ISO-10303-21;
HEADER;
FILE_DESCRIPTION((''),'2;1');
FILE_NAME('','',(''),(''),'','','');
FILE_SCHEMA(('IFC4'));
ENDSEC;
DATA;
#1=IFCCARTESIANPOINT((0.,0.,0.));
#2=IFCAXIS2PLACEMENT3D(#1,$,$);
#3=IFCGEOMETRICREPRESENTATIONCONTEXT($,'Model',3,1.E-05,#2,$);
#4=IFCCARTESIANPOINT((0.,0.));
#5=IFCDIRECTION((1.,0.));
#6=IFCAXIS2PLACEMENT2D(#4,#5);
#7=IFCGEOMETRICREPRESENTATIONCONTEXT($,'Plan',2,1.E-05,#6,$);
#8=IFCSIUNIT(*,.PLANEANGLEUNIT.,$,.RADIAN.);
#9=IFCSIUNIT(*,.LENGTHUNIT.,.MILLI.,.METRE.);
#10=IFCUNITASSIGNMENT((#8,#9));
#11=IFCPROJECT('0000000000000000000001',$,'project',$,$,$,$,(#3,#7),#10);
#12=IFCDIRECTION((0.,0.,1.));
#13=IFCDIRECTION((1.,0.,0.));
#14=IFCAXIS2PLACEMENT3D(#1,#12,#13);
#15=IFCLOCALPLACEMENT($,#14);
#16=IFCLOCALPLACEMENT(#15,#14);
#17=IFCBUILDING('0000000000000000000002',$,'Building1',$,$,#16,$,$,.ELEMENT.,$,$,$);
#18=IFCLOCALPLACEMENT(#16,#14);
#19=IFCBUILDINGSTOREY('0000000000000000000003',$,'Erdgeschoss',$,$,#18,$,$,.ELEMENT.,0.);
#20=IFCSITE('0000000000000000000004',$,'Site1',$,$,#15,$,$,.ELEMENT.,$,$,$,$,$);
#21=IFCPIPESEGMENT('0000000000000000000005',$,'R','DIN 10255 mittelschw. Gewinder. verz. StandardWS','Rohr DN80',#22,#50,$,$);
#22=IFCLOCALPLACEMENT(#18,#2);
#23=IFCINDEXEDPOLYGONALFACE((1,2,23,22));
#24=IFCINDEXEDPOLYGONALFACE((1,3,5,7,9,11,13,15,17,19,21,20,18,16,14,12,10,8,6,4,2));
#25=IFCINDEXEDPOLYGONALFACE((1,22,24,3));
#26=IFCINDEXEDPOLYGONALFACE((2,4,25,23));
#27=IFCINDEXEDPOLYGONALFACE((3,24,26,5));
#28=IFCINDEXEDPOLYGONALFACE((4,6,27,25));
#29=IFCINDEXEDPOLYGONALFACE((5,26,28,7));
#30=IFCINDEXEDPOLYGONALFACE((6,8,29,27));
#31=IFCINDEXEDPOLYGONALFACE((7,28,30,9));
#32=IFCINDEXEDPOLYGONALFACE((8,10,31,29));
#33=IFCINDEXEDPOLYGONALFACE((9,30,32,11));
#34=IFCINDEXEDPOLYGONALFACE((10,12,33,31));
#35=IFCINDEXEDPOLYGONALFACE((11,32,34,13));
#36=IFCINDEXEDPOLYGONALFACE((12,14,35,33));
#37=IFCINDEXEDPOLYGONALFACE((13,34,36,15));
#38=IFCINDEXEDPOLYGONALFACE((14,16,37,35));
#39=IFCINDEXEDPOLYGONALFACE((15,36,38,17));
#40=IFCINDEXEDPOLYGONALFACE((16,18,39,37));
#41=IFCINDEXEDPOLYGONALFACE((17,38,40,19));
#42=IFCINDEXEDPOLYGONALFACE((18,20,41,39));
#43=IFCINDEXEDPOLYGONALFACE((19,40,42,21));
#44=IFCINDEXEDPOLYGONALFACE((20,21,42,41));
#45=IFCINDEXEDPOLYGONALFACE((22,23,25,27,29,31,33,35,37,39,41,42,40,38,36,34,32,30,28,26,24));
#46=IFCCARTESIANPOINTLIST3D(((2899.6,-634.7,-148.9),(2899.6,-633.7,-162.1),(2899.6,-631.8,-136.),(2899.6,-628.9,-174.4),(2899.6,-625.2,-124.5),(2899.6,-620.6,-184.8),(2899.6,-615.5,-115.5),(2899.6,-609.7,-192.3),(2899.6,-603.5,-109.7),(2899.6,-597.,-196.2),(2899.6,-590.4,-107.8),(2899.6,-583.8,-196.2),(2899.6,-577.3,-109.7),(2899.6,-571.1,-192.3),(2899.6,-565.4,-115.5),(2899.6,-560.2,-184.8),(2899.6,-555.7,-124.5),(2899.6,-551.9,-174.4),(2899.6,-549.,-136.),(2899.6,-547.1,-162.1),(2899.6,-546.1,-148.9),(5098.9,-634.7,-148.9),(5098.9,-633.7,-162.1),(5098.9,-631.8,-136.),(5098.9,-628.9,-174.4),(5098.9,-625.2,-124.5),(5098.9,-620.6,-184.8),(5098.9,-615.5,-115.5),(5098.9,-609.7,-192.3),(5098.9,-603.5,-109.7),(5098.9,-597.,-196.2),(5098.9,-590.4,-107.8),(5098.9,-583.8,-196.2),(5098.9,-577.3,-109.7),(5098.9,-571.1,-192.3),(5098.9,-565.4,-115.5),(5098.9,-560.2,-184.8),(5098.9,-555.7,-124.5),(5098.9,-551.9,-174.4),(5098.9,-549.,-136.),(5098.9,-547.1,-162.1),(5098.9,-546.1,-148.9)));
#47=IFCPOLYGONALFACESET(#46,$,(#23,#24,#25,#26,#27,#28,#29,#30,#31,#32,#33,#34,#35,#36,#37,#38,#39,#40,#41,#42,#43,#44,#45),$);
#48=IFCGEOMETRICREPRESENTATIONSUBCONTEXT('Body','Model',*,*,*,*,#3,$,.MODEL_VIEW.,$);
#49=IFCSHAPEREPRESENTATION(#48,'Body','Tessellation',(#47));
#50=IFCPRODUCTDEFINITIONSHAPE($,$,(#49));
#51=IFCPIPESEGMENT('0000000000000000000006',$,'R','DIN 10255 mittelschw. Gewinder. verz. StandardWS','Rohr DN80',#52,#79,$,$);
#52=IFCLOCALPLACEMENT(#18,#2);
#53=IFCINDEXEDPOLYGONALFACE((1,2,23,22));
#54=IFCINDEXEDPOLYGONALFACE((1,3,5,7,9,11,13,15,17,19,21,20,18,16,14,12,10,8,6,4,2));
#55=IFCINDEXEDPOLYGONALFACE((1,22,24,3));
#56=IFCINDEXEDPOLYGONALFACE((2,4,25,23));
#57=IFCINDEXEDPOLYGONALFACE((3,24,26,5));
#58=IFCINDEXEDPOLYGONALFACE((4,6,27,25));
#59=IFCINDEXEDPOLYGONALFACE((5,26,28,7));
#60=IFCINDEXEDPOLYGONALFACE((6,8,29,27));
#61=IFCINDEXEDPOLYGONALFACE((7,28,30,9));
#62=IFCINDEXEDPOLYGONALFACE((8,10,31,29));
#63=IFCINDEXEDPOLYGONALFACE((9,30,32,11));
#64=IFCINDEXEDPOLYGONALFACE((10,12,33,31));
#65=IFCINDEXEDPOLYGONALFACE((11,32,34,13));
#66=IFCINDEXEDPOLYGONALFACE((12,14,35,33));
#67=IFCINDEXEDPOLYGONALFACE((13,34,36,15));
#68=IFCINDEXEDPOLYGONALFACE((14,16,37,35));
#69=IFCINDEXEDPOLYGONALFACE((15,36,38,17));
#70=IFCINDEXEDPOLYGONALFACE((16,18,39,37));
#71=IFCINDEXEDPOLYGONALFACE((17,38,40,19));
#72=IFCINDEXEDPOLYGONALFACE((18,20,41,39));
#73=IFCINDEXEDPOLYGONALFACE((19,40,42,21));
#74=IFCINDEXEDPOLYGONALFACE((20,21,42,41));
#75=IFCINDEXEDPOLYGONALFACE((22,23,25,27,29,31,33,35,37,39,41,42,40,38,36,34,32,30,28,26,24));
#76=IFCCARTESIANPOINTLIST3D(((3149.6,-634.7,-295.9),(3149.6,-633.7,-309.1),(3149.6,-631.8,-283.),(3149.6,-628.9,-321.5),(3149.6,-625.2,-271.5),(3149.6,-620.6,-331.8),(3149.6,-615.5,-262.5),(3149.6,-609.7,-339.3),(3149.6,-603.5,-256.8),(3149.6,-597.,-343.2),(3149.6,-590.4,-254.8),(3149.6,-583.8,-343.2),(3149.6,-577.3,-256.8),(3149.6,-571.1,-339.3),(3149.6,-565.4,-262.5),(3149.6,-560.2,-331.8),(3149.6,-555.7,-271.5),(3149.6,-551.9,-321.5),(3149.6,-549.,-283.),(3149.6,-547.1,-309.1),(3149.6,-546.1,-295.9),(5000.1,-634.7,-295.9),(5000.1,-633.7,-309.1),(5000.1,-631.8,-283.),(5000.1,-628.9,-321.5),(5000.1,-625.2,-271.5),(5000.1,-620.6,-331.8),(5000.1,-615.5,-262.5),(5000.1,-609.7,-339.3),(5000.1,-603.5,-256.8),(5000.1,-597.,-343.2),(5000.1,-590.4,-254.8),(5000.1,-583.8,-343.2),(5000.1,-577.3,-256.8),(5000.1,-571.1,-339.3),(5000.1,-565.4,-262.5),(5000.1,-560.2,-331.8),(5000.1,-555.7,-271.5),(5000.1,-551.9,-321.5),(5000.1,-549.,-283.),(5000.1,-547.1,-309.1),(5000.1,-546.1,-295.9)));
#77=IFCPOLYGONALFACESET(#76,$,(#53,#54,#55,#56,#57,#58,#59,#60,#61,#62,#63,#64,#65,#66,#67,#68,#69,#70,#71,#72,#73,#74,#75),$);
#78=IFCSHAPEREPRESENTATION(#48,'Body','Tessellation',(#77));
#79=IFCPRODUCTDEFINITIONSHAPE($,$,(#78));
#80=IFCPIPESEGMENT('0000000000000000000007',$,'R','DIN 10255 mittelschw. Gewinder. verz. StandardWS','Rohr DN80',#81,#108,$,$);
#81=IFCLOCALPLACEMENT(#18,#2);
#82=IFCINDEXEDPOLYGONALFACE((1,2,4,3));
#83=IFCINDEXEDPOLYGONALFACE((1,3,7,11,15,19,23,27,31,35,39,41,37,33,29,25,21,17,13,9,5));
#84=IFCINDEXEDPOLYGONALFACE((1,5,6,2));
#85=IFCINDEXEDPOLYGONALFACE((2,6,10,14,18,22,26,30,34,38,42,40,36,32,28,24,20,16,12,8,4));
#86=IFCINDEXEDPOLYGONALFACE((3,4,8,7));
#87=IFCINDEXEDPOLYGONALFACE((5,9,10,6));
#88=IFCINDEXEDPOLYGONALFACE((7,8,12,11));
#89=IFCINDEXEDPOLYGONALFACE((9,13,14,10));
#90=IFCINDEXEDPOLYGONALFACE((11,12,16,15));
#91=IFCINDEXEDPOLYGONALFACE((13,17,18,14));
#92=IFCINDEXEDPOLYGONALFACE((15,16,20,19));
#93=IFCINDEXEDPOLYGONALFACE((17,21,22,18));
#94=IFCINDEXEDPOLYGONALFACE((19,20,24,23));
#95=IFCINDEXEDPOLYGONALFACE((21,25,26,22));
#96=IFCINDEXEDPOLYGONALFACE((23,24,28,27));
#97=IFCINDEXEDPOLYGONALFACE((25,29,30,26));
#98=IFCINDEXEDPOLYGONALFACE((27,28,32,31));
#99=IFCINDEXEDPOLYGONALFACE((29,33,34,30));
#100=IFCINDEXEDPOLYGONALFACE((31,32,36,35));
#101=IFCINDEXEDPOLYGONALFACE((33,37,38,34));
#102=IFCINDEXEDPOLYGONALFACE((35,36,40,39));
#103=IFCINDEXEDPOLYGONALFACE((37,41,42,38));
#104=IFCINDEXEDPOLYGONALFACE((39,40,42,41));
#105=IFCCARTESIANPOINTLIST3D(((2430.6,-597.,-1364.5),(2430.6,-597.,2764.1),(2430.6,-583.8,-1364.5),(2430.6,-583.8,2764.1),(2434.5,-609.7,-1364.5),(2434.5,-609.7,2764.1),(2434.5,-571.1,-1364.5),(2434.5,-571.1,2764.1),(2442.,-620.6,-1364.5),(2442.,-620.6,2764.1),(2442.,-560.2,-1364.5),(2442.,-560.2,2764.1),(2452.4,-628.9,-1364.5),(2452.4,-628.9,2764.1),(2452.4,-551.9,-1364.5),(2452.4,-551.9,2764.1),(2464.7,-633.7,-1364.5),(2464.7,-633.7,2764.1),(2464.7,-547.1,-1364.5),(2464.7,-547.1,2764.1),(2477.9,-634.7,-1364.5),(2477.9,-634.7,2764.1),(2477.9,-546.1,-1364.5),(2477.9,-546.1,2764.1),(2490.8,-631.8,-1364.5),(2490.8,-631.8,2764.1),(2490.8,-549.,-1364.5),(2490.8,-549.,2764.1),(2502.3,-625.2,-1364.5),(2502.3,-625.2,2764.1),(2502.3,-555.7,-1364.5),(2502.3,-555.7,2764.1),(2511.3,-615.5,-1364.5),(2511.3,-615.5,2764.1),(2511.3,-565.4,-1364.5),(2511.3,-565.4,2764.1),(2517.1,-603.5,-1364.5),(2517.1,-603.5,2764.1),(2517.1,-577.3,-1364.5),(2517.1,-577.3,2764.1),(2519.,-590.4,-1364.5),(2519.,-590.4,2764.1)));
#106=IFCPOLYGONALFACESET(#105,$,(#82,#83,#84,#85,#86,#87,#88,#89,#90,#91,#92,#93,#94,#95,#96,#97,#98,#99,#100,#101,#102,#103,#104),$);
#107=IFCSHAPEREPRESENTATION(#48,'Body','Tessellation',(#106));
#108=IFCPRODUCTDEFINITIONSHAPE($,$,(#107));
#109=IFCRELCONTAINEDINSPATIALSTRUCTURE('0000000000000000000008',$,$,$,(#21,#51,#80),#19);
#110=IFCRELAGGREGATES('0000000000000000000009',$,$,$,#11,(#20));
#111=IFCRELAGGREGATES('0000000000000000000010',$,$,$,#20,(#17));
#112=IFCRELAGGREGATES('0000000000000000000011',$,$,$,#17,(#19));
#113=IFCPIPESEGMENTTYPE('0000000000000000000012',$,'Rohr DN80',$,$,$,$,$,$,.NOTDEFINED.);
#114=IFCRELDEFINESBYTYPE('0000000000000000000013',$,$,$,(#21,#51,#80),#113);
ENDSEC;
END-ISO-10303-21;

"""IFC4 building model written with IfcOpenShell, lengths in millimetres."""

from ifc_helpers import new_model, si_unit, frame, origin, origin_with_axes, origin_2d_with_axis, place, context, subcontext, project, spatial, circle, extrude, type_object, element, save


model = new_model("IFC4")

# Units and contexts
model_context = context("Model", 3, precision=1e-05, world=origin())
plan_context = context("Plan", 2, precision=1e-05, world=origin_2d_with_axis())
body_context = subcontext(model_context, "Body", "Model", "MODEL_VIEW")
ifc_project = project(units=[si_unit("PLANEANGLEUNIT", "RADIAN"), si_unit("LENGTHUNIT", "METRE", prefix="MILLI")], contexts=[model_context, plan_context])

# Site, building, storey
site_placement = place(None, origin_with_axes())
site = spatial("IfcSite", under=ifc_project, at=site_placement, Name="Site1", CompositionType="ELEMENT")
building_placement = place(site_placement, origin_with_axes())
building = spatial("IfcBuilding", under=site, at=building_placement, Name="Building1", CompositionType="ELEMENT")
storey_placement = place(building_placement, origin_with_axes())
storey = spatial("IfcBuildingStorey", under=building, at=storey_placement, Name="Erdgeschoss", CompositionType="ELEMENT", Elevation=0.0)

# Pipe segments
pipe_segment_type_1 = type_object("IfcPipeSegmentType", Name="Rohr DN80", PredefinedType="NOTDEFINED")
pipe_segment_1_placement = place(storey_placement, frame((3999.2, -590.3, -152.2), z_axis=(0.0, 0.0, 1.0), x_axis=(1.0, 0.0, 0.0)))
element("IfcPipeSegment", 1, at=pipe_segment_1_placement, inside=storey, type_object=pipe_segment_type_1, Name="R", Description="DIN 10255 mittelschw. Gewinder. verz. StandardWS", ObjectType="Rohr DN80", context=body_context, shape_type="SolidModel", body=[
    extrude(circle(Radius=44.5, at=origin_2d_with_axis()), frame((-1099.6, -0.2, 0.0), z_axis=(1.0, 0.0, 0.0), x_axis=(0.0, 0.0, 1.0)), (0.0, 0.0, 1.0), 2199.3),
])
pipe_segment_2_placement = place(storey_placement, frame((4074.8, -590.3, -299.2), z_axis=(0.0, 0.0, 1.0), x_axis=(1.0, 0.0, 0.0)))
element("IfcPipeSegment", 2, at=pipe_segment_2_placement, inside=storey, type_object=pipe_segment_type_1, Name="R", Description="DIN 10255 mittelschw. Gewinder. verz. StandardWS", ObjectType="Rohr DN80", context=body_context, shape_type="SolidModel", body=[
    extrude(circle(Radius=44.5, at=origin_2d_with_axis()), frame((-925.3, -0.2, 0.0), z_axis=(1.0, 0.0, 0.0), x_axis=(0.0, 0.0, 1.0)), (0.0, 0.0, 1.0), 1850.5),
])
pipe_segment_3_placement = place(storey_placement, frame((2474.6, -590.6, 699.8), z_axis=(0.0, 0.0, 1.0), x_axis=(1.0, 0.0, 0.0)))
element("IfcPipeSegment", 3, at=pipe_segment_3_placement, inside=storey, type_object=pipe_segment_type_1, Name="R", Description="DIN 10255 mittelschw. Gewinder. verz. StandardWS", ObjectType="Rohr DN80", context=body_context, shape_type="SolidModel", body=[
    extrude(circle(Radius=44.5, at=origin_2d_with_axis()), frame((0.0, 0.1, -2064.3), z_axis=(0.0, 0.0, 1.0), x_axis=(1.0, 0.0, 0.0)), (0.0, 0.0, 1.0), 4128.7),
])

save(model, "model.ifc")
